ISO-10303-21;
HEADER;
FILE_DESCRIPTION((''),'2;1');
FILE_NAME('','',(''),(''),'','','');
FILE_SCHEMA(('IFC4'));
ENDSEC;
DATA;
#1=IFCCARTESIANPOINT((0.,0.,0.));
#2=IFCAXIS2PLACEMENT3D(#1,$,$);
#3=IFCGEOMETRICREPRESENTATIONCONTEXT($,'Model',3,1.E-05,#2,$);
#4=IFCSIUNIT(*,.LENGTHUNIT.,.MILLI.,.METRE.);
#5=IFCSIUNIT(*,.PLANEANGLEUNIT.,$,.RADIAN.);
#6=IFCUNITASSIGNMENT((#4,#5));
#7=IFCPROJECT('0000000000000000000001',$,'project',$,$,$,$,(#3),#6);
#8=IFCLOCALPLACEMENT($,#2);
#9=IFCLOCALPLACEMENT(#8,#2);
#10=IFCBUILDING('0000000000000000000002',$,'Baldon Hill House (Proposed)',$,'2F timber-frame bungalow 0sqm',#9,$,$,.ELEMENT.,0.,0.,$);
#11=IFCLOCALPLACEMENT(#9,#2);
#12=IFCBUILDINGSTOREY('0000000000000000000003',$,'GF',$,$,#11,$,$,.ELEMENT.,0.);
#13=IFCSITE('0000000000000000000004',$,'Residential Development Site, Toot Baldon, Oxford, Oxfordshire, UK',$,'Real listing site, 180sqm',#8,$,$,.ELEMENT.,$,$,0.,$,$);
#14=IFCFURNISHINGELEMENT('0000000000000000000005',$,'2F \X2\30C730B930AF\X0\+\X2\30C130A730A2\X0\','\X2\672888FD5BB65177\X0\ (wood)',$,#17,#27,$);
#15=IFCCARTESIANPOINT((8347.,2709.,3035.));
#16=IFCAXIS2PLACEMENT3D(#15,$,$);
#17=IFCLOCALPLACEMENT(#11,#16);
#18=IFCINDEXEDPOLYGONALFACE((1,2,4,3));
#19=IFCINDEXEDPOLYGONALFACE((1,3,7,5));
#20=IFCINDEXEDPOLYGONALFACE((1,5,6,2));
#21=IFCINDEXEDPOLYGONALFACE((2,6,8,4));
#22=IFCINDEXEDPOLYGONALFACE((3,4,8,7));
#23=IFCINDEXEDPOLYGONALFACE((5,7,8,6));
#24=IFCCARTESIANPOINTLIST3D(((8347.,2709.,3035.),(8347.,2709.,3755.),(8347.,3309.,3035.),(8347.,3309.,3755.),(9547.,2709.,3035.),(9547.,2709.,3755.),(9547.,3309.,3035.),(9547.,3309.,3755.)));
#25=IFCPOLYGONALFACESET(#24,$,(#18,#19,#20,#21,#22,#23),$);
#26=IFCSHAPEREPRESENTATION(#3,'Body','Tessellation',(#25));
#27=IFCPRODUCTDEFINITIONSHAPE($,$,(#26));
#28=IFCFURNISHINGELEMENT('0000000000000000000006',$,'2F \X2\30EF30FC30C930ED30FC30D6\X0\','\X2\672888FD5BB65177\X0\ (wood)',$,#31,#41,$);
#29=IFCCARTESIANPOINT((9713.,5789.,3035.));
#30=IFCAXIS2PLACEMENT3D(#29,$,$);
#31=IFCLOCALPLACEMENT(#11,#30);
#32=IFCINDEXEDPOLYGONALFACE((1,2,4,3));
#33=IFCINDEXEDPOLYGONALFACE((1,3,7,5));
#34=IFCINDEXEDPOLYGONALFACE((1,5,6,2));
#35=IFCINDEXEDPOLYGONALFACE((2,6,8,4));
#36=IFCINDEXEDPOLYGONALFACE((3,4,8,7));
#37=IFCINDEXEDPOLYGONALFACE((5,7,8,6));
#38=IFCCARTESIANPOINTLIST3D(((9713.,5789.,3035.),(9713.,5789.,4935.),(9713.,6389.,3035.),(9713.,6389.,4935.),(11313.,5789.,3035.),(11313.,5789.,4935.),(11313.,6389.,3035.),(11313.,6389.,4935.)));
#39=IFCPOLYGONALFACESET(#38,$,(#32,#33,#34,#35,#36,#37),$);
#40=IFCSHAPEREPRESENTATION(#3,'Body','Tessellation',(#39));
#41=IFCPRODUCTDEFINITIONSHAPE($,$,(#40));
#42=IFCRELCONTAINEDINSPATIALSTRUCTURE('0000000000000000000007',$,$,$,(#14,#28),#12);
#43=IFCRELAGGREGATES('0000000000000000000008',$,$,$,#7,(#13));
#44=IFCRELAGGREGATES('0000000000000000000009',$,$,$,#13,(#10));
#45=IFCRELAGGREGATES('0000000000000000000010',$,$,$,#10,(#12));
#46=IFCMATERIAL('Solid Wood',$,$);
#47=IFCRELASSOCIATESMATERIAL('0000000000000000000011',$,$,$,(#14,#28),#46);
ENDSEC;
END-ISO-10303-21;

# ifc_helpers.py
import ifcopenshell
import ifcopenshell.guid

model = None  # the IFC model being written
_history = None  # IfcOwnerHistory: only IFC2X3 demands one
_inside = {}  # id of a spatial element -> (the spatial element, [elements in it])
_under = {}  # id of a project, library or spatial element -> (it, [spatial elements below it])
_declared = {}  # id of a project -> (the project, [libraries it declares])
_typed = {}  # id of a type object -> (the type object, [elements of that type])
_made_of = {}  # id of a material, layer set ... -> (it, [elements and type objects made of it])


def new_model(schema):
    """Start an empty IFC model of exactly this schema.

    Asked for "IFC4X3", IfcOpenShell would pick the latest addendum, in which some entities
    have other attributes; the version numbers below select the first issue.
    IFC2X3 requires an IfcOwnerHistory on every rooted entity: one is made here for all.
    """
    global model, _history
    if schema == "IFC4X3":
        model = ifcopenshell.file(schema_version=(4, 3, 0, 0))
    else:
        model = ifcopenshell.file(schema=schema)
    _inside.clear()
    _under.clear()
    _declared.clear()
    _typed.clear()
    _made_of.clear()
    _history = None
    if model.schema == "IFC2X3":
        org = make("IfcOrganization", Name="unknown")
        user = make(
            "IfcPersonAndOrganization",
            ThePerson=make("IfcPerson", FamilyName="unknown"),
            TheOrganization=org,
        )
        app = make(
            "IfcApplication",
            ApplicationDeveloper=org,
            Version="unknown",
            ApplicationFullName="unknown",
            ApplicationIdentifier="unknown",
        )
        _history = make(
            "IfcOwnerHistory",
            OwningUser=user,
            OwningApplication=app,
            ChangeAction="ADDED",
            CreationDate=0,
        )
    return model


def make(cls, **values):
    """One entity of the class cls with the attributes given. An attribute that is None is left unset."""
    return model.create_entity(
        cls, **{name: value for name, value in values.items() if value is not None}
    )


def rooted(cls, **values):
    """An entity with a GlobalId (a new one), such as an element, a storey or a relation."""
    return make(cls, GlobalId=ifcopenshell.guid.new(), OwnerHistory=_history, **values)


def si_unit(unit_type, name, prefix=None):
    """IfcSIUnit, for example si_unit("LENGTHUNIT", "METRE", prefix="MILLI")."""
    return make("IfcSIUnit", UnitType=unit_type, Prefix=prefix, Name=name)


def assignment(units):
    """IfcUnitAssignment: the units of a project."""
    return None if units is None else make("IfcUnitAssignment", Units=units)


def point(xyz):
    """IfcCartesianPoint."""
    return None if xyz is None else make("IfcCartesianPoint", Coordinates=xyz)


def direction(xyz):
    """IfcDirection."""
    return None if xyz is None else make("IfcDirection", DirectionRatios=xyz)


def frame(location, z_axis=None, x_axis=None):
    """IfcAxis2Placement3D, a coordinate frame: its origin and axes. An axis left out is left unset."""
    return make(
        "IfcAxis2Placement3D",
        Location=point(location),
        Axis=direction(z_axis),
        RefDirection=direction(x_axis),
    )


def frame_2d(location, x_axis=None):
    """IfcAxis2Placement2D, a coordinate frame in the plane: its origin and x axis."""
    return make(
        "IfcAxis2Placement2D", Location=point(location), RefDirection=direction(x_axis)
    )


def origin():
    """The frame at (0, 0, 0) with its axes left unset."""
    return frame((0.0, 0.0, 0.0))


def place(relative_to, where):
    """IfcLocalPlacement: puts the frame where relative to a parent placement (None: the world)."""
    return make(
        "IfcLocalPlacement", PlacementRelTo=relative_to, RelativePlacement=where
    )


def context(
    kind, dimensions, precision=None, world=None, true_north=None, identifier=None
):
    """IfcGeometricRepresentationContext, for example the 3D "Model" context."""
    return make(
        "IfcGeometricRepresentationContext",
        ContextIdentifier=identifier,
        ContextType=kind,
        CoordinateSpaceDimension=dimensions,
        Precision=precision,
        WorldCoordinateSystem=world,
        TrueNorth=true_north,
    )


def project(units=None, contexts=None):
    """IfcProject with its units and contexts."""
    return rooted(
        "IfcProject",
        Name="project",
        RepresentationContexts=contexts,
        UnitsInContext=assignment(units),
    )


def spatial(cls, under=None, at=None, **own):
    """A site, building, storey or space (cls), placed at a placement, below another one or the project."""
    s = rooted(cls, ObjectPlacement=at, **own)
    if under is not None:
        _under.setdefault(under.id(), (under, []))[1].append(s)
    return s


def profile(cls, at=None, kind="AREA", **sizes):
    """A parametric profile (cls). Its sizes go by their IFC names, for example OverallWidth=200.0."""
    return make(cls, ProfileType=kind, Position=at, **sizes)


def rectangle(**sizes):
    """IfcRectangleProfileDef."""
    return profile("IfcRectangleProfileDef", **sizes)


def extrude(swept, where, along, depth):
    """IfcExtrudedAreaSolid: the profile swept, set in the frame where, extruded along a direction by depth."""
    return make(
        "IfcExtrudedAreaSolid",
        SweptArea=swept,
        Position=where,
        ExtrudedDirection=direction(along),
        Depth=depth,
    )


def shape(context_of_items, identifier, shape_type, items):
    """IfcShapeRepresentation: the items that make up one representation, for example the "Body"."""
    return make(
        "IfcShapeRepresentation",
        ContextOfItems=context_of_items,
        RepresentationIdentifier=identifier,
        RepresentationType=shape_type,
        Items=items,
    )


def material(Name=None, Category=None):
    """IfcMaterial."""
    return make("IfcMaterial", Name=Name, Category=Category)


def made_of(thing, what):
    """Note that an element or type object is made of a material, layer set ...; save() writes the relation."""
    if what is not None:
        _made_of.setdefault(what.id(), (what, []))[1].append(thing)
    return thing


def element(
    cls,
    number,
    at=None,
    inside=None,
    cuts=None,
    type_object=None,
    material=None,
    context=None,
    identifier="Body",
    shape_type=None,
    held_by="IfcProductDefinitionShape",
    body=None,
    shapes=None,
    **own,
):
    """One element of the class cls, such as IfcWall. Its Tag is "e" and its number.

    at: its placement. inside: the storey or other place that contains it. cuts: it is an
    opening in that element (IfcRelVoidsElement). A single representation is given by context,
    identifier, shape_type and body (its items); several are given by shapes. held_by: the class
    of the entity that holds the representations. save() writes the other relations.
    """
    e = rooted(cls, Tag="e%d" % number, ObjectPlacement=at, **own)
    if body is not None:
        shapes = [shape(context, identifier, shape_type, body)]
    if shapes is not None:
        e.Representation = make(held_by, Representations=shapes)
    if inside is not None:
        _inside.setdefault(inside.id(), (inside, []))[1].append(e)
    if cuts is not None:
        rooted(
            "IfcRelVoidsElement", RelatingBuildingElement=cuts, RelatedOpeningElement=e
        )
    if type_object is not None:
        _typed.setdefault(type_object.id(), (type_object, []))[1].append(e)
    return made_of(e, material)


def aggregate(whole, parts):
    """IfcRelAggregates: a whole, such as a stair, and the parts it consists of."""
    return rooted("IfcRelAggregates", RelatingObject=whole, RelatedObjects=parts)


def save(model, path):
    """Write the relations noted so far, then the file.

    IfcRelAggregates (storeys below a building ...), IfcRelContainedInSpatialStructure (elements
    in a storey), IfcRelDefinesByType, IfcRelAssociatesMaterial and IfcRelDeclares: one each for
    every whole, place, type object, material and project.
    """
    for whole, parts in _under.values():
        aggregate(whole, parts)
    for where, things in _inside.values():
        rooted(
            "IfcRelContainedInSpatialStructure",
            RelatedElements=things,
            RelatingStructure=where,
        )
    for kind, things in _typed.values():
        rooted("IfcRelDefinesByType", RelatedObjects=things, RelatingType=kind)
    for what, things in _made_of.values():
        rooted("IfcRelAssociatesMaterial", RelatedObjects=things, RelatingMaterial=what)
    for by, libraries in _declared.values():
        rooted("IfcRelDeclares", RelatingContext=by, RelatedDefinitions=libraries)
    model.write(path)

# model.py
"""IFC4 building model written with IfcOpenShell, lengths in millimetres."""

from ifc_helpers import new_model, si_unit, frame, frame_2d, origin, place, context, project, spatial, rectangle, extrude, material, element, save


model = new_model("IFC4")

# Units and contexts
model_context = context("Model", 3, precision=1e-05, world=origin())
ifc_project = project(units=[si_unit("LENGTHUNIT", "METRE", prefix="MILLI"), si_unit("PLANEANGLEUNIT", "RADIAN")], contexts=[model_context])

# Site, building, storey
site_placement = place(None, origin())
site = spatial("IfcSite", under=ifc_project, at=site_placement, Name="Residential Development Site, Toot Baldon, Oxford, Oxfordshire, UK", ObjectType="Real listing site, 180sqm", CompositionType="ELEMENT", RefElevation=0.0)
building_placement = place(site_placement, origin())
building = spatial("IfcBuilding", under=site, at=building_placement, Name="Baldon Hill House (Proposed)", ObjectType="2F timber-frame bungalow 0sqm", CompositionType="ELEMENT", ElevationOfRefHeight=0.0, ElevationOfTerrain=0.0)
storey_placement = place(building_placement, origin())
storey = spatial("IfcBuildingStorey", under=building, at=storey_placement, Name="GF", CompositionType="ELEMENT", Elevation=0.0)

# Shared definitions
ifc_material_1 = material(Name="Solid Wood")

# Furnishing elements
furnishing_1_placement = place(storey_placement, frame((8347.0, 2709.0, 3035.0)))
element("IfcFurnishingElement", 1, at=furnishing_1_placement, inside=storey, material=ifc_material_1, Name="2F デスク+チェア", Description="木製家具 (wood)", context=model_context, shape_type="SweptSolid", body=[
    extrude(rectangle(XDim=1200.0, YDim=600.0, at=frame_2d((600.0, 300.0))), frame((8347.0, 2709.0, 3035.0)), (0.0, 0.0, 1.0), 720.0),
])
furnishing_2_placement = place(storey_placement, frame((9713.0, 5789.0, 3035.0)))
element("IfcFurnishingElement", 2, at=furnishing_2_placement, inside=storey, material=ifc_material_1, Name="2F ワードローブ", Description="木製家具 (wood)", context=model_context, shape_type="SweptSolid", body=[
    extrude(rectangle(XDim=1600.0, YDim=600.0, at=frame_2d((800.0, 300.0))), frame((9713.0, 5789.0, 3035.0)), (0.0, 0.0, 1.0), 1900.0),
])

save(model, "model.ifc")
